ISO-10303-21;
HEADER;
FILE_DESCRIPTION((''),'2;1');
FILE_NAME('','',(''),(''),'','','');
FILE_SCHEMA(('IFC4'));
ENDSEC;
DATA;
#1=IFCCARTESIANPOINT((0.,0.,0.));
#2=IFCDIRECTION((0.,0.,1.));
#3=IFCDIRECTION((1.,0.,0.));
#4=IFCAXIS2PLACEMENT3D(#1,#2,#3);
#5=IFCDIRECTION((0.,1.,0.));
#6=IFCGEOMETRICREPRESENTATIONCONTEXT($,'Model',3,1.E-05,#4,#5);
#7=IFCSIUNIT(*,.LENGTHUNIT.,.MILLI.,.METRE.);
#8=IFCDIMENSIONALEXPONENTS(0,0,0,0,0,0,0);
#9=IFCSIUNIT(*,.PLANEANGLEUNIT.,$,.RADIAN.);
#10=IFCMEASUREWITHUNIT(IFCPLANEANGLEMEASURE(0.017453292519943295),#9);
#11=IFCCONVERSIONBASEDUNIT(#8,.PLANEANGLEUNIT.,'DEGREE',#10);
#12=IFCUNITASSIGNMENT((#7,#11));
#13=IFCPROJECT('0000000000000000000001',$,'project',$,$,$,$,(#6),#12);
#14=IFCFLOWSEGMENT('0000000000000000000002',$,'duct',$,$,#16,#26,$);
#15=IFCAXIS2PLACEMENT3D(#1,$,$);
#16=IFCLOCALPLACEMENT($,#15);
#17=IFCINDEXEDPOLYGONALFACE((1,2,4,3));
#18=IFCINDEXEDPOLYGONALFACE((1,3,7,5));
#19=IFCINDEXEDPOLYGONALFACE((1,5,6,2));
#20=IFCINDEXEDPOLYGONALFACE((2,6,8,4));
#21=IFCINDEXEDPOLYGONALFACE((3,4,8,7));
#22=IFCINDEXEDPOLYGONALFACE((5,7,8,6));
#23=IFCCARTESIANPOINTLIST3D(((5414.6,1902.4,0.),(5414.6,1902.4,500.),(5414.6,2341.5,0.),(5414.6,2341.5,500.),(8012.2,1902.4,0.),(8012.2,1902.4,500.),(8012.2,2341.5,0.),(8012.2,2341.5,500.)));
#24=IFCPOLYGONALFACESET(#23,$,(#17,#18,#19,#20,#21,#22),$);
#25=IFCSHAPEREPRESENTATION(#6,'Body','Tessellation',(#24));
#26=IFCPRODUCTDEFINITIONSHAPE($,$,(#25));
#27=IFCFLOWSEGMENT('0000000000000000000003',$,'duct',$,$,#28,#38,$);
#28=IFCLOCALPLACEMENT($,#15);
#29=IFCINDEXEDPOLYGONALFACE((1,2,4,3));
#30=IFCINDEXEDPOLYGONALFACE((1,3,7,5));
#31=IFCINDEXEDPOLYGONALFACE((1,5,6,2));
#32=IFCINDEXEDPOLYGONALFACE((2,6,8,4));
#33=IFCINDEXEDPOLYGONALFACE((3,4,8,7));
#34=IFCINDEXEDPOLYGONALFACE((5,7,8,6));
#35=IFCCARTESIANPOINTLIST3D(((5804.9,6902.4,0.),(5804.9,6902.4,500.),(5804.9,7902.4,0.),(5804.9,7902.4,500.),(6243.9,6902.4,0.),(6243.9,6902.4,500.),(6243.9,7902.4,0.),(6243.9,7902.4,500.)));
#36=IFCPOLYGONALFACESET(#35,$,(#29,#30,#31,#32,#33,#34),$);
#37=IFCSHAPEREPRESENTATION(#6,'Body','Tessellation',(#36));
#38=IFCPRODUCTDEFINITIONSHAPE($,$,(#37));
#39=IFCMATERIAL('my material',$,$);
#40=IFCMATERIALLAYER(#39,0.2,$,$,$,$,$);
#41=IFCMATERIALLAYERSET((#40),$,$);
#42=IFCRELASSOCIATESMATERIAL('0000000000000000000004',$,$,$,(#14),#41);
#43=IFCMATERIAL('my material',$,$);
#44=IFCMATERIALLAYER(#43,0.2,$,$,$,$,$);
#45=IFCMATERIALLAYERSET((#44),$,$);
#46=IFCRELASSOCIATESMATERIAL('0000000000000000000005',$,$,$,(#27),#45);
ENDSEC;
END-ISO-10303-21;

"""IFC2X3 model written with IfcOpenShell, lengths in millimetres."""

from ifc_helpers import new_model, entity, si_unit, converted_unit, direction, origin_with_axes, place, context, project, polyline, outline, extrude, material, layer, layer_set, layer_usage, element, save


model = new_model("IFC2X3")

# Units and contexts
model_context = context("Model", 3, precision=1e-05, world=origin_with_axes(), true_north=direction((0.0, 1.0, 0.0)))
ifc_project = project(units=[si_unit("LENGTHUNIT", "METRE", prefix="MILLI"), converted_unit("PLANEANGLEUNIT", "DEGREE", entity("IfcPlaneAngleMeasure", 0.017453292519943295), si_unit("PLANEANGLEUNIT", "RADIAN"), dimensions=[0, 0, 0, 0, 0, 0, 0])], contexts=[model_context])

# Flow segments
ifc_material_1 = material(Name="my material")
ifc_layer_1 = layer(ifc_material_1, 0.2)
ifc_layer_set_1 = layer_set([ifc_layer_1])
ifc_layer_usage_1 = layer_usage(ifc_layer_set_1, "AXIS2", "POSITIVE", -0.1)
flow_segment_1_placement = place(None, origin_with_axes())
element("IfcFlowSegment", 1, at=flow_segment_1_placement, material=ifc_layer_usage_1, Name="duct", context=model_context, shape_type="SweptSolid", body=[
    extrude(outline(polyline([(5414.6, 1902.4), (8012.2, 1902.4), (8012.2, 2341.5), (5414.6, 2341.5), (5414.6, 1902.4)])), origin_with_axes(), (0.0, 0.0, 1.0), 500.0),
])
ifc_material_2 = material(Name="my material")
ifc_layer_2 = layer(ifc_material_2, 0.2)
ifc_layer_set_2 = layer_set([ifc_layer_2])
ifc_layer_usage_2 = layer_usage(ifc_layer_set_2, "AXIS2", "POSITIVE", -0.1)
flow_segment_2_placement = place(None, origin_with_axes())
element("IfcFlowSegment", 2, at=flow_segment_2_placement, material=ifc_layer_usage_2, Name="duct", context=model_context, shape_type="SweptSolid", body=[
    extrude(outline(polyline([(5804.9, 6902.4), (6243.9, 6902.4), (6243.9, 7902.4), (5804.9, 7902.4), (5804.9, 6902.4)])), origin_with_axes(), (0.0, 0.0, 1.0), 500.0),
])

save(model, "model.ifc")
